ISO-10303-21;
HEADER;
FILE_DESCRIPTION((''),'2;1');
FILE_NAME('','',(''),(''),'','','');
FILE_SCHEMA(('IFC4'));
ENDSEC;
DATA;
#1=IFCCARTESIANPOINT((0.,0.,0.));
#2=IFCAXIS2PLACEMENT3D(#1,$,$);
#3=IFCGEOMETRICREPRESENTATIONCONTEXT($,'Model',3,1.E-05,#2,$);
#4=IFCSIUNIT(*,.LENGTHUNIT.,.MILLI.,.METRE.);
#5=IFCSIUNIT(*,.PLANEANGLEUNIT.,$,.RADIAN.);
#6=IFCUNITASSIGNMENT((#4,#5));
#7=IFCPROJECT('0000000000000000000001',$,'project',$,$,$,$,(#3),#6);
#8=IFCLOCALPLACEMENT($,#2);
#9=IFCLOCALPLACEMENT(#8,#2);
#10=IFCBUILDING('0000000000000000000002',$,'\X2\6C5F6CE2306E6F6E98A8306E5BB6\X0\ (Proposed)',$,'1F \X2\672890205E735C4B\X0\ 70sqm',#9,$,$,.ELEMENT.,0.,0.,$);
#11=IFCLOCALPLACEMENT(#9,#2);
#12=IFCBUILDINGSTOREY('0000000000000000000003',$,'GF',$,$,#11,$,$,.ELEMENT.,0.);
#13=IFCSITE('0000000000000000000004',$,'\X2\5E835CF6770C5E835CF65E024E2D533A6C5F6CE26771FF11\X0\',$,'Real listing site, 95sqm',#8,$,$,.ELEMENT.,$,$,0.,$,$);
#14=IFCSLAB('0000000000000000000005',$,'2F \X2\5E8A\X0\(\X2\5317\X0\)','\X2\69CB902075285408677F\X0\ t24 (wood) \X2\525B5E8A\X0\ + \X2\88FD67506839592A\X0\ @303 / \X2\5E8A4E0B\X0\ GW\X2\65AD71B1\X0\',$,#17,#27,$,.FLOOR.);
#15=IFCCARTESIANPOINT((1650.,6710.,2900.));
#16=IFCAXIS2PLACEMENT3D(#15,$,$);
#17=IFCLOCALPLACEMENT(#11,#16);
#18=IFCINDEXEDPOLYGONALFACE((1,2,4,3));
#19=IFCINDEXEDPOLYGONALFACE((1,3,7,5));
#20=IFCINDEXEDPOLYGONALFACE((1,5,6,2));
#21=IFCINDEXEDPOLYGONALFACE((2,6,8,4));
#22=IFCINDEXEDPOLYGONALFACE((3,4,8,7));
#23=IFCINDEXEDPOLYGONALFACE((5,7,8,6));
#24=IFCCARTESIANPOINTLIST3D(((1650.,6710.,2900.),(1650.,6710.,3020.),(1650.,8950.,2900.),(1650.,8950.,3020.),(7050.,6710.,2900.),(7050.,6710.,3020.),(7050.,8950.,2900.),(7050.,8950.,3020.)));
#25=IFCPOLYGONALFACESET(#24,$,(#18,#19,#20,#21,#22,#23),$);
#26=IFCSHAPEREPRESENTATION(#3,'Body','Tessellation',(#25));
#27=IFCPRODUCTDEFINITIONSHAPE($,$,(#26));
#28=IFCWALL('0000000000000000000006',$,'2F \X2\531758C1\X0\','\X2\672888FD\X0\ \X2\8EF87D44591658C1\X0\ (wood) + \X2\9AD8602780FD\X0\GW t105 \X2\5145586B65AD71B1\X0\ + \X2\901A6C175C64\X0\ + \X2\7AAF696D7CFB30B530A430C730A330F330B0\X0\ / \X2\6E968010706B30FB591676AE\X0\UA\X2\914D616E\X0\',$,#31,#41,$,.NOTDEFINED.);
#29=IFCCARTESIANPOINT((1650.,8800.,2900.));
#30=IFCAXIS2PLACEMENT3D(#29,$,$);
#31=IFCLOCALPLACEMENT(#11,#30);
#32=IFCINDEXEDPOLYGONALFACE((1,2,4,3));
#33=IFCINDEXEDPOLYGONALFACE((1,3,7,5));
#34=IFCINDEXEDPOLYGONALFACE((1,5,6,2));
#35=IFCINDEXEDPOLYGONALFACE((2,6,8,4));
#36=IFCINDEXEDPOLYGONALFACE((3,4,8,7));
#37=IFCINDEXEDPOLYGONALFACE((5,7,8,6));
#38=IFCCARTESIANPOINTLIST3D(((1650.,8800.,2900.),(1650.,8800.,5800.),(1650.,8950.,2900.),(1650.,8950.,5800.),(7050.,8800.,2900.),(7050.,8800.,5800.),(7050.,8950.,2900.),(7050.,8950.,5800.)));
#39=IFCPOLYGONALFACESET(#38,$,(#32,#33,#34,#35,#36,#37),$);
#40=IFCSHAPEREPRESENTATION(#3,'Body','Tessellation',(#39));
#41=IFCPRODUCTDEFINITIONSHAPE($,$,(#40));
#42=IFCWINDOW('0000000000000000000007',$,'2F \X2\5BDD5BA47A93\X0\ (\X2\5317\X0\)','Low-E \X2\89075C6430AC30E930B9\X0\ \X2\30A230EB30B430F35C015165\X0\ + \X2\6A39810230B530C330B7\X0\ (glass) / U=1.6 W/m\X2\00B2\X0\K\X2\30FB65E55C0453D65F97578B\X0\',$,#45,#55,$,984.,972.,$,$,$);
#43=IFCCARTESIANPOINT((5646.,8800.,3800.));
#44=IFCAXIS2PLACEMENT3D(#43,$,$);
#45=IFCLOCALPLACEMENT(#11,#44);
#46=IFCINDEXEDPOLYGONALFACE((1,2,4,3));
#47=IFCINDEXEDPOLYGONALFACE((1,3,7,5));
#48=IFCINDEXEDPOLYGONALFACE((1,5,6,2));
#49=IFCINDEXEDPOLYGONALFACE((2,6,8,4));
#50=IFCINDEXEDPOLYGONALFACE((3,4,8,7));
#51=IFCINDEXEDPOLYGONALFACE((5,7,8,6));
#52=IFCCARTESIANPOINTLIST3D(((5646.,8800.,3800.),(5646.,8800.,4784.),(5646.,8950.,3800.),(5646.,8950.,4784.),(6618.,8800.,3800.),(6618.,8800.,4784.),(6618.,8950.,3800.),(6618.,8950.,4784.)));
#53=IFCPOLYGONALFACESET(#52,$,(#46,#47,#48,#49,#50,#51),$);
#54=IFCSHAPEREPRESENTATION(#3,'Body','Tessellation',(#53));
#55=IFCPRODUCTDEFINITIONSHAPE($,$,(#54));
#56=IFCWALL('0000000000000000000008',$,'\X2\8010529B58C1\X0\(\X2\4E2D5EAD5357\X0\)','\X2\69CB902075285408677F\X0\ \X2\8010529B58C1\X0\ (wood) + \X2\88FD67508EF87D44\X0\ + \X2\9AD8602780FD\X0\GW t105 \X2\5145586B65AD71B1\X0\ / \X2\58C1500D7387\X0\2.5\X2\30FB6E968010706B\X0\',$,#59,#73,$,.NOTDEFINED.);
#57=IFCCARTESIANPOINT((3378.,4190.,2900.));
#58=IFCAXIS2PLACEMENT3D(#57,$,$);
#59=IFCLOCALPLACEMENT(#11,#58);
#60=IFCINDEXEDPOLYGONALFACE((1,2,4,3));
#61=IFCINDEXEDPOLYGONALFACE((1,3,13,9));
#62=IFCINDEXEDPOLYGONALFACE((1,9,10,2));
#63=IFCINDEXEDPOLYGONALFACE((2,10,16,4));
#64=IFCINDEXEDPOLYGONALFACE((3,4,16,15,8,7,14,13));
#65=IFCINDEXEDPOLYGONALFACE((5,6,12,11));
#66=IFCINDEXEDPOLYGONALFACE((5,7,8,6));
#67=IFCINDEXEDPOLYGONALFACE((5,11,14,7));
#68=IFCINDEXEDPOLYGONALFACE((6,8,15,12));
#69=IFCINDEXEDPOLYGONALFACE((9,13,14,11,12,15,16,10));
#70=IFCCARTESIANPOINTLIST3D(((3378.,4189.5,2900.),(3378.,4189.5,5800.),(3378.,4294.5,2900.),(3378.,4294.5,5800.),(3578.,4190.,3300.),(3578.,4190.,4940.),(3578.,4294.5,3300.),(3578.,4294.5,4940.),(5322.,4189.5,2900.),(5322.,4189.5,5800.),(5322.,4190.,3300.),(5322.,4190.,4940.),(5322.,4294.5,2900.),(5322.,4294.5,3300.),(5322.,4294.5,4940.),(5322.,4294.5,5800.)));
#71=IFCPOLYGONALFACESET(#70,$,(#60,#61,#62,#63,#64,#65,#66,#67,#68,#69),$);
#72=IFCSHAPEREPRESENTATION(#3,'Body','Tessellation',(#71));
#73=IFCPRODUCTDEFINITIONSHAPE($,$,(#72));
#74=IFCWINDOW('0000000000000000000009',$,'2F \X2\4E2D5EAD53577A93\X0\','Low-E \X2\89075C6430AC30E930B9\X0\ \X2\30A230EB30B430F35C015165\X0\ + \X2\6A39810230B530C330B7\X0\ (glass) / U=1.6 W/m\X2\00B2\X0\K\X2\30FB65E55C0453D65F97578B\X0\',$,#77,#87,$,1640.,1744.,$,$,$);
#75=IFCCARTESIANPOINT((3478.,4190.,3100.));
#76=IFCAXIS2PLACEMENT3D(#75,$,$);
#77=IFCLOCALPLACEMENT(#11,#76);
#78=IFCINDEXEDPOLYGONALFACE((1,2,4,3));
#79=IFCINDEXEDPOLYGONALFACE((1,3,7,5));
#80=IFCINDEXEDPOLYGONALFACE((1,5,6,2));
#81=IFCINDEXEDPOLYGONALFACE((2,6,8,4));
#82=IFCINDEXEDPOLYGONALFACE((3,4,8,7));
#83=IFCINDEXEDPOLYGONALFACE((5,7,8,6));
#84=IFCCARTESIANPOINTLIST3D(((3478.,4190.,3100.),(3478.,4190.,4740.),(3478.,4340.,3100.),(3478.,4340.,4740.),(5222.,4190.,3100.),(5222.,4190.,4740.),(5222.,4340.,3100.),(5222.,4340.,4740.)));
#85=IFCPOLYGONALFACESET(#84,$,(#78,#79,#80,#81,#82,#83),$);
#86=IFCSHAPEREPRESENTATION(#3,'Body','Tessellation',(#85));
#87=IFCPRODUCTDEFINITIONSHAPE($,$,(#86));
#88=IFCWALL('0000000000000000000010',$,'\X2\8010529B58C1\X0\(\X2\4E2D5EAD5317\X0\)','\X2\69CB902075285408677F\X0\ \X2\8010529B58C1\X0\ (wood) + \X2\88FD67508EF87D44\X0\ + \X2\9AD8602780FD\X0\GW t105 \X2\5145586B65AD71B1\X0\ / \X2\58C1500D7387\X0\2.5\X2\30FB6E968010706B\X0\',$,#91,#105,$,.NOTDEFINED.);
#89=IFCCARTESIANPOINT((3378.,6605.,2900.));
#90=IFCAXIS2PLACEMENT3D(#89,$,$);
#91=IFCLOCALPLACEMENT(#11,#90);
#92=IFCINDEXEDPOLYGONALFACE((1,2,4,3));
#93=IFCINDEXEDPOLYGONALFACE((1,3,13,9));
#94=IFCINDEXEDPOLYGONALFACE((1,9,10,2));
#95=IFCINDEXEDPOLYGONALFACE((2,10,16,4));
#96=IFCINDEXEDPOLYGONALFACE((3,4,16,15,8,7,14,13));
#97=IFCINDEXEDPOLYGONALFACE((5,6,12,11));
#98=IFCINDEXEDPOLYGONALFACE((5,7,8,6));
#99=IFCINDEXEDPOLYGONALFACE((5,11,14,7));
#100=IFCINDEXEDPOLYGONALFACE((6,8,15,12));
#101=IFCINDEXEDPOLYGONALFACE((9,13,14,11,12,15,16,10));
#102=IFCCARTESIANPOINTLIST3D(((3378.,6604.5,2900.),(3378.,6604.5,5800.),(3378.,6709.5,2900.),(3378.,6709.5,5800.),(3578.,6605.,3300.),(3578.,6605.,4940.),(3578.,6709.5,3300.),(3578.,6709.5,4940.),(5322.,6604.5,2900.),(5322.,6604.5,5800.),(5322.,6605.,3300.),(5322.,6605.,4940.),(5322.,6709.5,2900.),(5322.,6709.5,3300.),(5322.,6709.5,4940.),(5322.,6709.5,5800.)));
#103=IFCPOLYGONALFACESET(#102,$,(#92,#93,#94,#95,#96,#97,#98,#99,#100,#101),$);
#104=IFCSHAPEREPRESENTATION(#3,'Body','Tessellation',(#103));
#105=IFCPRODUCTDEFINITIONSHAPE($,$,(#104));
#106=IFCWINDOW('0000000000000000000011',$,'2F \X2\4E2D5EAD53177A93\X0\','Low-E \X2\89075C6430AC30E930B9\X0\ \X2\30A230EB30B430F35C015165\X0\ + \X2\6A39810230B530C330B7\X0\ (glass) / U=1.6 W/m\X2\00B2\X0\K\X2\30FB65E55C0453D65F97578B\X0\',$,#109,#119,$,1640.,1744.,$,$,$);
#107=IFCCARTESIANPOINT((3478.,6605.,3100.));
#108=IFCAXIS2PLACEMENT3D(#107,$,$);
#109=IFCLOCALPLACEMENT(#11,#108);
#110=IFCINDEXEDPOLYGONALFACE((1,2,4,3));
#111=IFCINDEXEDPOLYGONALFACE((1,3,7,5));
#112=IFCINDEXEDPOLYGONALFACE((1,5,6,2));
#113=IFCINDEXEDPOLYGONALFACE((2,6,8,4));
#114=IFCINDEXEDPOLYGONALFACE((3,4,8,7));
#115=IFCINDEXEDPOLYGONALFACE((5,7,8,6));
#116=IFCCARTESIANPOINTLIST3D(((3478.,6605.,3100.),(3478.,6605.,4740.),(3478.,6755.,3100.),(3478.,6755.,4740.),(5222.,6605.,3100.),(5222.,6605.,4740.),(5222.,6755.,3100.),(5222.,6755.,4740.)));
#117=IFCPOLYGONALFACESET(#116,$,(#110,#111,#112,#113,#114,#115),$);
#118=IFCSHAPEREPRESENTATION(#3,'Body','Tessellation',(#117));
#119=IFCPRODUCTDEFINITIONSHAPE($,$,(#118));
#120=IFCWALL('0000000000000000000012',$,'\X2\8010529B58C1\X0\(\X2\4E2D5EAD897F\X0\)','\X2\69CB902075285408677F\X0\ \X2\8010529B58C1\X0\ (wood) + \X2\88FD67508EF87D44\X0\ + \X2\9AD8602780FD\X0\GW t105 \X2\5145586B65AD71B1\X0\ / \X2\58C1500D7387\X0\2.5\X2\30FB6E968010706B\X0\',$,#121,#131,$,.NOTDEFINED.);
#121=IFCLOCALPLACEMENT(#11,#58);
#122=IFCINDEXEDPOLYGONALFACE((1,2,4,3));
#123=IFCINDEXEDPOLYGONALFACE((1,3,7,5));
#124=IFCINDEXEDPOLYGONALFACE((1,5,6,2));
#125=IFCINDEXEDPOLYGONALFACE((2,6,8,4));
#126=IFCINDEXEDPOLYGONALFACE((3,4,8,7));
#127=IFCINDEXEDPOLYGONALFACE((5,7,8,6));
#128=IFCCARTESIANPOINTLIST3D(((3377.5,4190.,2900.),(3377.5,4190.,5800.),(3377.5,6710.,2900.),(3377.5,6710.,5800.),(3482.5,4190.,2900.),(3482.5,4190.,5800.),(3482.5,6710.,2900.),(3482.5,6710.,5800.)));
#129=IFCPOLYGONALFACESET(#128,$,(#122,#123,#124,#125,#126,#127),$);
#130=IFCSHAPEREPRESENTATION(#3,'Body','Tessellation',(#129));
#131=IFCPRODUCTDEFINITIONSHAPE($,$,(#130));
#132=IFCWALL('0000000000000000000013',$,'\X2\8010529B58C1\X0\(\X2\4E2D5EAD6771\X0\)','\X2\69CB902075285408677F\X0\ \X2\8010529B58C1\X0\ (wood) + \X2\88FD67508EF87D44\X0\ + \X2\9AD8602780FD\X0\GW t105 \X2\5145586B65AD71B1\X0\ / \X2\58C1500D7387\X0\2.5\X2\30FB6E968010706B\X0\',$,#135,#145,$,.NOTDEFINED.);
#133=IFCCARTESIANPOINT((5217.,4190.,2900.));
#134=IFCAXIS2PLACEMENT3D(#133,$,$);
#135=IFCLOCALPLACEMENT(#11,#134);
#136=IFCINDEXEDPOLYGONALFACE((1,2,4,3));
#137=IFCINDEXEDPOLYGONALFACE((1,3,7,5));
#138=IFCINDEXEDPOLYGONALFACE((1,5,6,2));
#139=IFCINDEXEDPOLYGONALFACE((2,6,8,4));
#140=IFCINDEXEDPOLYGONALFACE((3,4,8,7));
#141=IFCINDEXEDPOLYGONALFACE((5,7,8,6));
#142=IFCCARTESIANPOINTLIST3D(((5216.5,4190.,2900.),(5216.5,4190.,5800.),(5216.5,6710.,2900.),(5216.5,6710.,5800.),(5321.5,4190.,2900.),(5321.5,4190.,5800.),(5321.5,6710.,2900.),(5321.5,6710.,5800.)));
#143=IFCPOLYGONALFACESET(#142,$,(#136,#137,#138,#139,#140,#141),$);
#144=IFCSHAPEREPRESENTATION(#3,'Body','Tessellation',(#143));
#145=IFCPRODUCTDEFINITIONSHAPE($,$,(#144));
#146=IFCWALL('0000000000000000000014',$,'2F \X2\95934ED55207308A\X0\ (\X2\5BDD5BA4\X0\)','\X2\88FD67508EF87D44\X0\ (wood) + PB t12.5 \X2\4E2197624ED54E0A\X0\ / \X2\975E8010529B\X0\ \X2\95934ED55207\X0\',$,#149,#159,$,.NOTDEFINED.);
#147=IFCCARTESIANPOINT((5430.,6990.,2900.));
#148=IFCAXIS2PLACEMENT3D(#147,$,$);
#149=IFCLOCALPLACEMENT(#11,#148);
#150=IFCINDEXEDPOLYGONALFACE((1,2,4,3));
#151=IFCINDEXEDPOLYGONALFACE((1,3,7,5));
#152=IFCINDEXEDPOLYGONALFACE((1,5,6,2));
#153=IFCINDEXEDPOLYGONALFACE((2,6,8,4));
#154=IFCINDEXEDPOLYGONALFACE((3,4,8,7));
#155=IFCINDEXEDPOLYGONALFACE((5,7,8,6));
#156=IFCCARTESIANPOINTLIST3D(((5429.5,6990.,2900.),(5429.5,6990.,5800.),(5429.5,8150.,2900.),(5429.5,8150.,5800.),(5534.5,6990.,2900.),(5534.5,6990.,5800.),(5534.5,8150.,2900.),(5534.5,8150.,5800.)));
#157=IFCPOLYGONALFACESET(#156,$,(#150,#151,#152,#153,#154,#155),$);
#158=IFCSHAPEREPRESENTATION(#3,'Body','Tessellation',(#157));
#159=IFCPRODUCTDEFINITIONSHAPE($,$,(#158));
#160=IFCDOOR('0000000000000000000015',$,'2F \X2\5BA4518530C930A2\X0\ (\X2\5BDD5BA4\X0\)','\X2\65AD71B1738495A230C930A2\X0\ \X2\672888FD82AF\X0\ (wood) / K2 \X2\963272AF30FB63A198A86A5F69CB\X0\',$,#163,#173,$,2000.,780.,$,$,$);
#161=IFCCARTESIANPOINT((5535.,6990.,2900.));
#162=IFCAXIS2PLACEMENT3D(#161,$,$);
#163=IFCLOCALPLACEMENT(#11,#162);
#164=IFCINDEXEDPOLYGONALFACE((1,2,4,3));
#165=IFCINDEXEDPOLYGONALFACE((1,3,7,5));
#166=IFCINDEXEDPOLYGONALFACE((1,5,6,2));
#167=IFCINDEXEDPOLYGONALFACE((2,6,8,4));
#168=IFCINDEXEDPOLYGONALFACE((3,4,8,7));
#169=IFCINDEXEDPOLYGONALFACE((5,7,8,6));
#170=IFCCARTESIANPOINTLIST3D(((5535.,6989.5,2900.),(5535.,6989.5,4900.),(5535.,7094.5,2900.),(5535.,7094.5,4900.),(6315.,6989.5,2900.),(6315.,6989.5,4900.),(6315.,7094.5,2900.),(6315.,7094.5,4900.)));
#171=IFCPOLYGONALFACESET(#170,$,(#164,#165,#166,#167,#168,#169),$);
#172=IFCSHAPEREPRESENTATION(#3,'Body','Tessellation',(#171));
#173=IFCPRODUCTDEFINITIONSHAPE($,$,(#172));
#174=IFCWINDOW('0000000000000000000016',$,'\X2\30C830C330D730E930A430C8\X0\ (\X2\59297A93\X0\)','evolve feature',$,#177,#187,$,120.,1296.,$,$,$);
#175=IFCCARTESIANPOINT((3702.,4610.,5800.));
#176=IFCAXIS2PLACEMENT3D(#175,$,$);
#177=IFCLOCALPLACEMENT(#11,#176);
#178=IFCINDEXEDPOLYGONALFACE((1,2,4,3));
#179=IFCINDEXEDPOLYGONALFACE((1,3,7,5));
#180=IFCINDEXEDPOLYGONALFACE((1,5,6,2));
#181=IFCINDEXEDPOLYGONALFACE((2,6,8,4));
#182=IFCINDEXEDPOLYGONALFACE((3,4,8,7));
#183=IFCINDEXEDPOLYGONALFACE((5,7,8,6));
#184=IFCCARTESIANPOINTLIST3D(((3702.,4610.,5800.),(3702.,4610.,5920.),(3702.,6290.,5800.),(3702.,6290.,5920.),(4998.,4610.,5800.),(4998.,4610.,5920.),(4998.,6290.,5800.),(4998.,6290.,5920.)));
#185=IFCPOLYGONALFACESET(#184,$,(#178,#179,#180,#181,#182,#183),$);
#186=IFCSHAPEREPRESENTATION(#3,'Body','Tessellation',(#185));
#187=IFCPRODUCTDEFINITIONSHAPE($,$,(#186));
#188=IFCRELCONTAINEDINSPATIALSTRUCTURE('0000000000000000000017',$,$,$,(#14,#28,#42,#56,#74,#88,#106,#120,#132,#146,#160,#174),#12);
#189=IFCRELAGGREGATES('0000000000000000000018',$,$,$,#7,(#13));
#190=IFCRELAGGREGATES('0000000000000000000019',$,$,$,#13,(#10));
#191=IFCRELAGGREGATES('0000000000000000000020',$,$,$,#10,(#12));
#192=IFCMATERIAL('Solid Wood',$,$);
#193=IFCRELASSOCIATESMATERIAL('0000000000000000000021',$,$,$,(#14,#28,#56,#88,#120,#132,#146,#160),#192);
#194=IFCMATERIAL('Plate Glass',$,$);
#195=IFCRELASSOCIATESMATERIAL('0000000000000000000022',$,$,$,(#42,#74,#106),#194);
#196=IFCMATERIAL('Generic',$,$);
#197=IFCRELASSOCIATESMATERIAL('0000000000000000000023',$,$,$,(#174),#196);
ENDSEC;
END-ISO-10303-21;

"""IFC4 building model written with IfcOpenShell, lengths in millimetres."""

from ifc_helpers import new_model, si_unit, frame, frame_2d, origin, place, context, project, spatial, rectangle, extrude, material, element, fill, save


model = new_model("IFC4")

# Units and contexts
model_context = context("Model", 3, precision=1e-05, world=origin())
ifc_project = project(units=[si_unit("LENGTHUNIT", "METRE", prefix="MILLI"), si_unit("PLANEANGLEUNIT", "RADIAN")], contexts=[model_context])

# Site, building, storey
site_placement = place(None, origin())
site = spatial("IfcSite", under=ifc_project, at=site_placement, Name="広島県広島市中区江波東１", ObjectType="Real listing site, 95sqm", CompositionType="ELEMENT", RefElevation=0.0)
building_placement = place(site_placement, origin())
building = spatial("IfcBuilding", under=site, at=building_placement, Name="江波の潮風の家 (Proposed)", ObjectType="1F 木造平屋 70sqm", CompositionType="ELEMENT", ElevationOfRefHeight=0.0, ElevationOfTerrain=0.0)
storey_placement = place(building_placement, origin())
storey = spatial("IfcBuildingStorey", under=building, at=storey_placement, Name="GF", CompositionType="ELEMENT", Elevation=0.0)

# Slab
ifc_material_1 = material(Name="Solid Wood")
slab_placement = place(storey_placement, frame((1650.0, 6710.0, 2900.0)))
element("IfcSlab", 1, at=slab_placement, inside=storey, material=ifc_material_1, Name="2F 床(北)", Description="構造用合板 t24 (wood) 剛床 + 製材根太 @303 / 床下 GW断熱", PredefinedType="FLOOR", context=model_context, shape_type="SweptSolid", body=[
    extrude(rectangle(XDim=5400.0, YDim=2240.0, at=frame_2d((2700.0, 1120.0))), frame((1650.0, 6710.0, 2900.0)), (0.0, 0.0, 1.0), 120.0),
])

# Walls, openings, windows
wall_1_placement = place(storey_placement, frame((1650.0, 8800.0, 2900.0)))
wall_1 = element("IfcWall", 2, at=wall_1_placement, inside=storey, material=ifc_material_1, Name="2F 北壁", Description="木製 軸組外壁 (wood) + 高性能GW t105 充填断熱 + 通気層 + 窯業系サイディング / 準耐火・外皮UA配慮", PredefinedType="NOTDEFINED", context=model_context, shape_type="SweptSolid", body=[
    extrude(rectangle(XDim=5400.0, YDim=150.0, at=frame_2d((2700.0, 75.0))), frame((1650.0, 8800.0, 2900.0)), (0.0, 0.0, 1.0), 2900.0),
])
opening_1_placement = place(storey_placement, frame((5646.0, 8800.0, 3800.0)))
opening_1 = element("IfcOpeningElement", 3, at=opening_1_placement, cuts=wall_1, PredefinedType="NOTDEFINED", context=model_context, shape_type="SweptSolid", body=[
    extrude(rectangle(XDim=972.0, YDim=150.0, at=frame_2d((486.0, 75.0))), frame((5646.0, 8800.0, 3800.0)), (0.0, 0.0, 1.0), 984.0),
])
ifc_material_2 = material(Name="Plate Glass")
window_1_placement = place(storey_placement, frame((5646.0, 8800.0, 3800.0)))
window_1 = element("IfcWindow", 4, at=window_1_placement, inside=storey, material=ifc_material_2, Name="2F 寝室窓 (北)", Description="Low-E 複層ガラス アルゴン封入 + 樹脂サッシ (glass) / U=1.6 W/m²K・日射取得型", OverallHeight=984.0, OverallWidth=972.0, context=model_context, shape_type="SweptSolid", body=[
    extrude(rectangle(XDim=972.0, YDim=150.0, at=frame_2d((486.0, 75.0))), frame((5646.0, 8800.0, 3800.0)), (0.0, 0.0, 1.0), 984.0),
])
fill(opening_1, window_1)
wall_2_placement = place(storey_placement, frame((3378.0, 4190.0, 2900.0)))
wall_2 = element("IfcWall", 5, at=wall_2_placement, inside=storey, material=ifc_material_1, Name="耐力壁(中庭南)", Description="構造用合板 耐力壁 (wood) + 製材軸組 + 高性能GW t105 充填断熱 / 壁倍率2.5・準耐火", PredefinedType="NOTDEFINED", context=model_context, shape_type="SweptSolid", body=[
    extrude(rectangle(XDim=1944.0, YDim=105.0, at=frame_2d((972.0, 52.0))), frame((3378.0, 4190.0, 2900.0)), (0.0, 0.0, 1.0), 2900.0),
])
opening_2_placement = place(storey_placement, frame((3478.0, 4190.0, 3100.0)))
opening_2 = element("IfcOpeningElement", 6, at=opening_2_placement, cuts=wall_2, PredefinedType="NOTDEFINED", context=model_context, shape_type="SweptSolid", body=[
    extrude(rectangle(XDim=1744.0, YDim=150.0, at=frame_2d((872.0, 75.0))), frame((3478.0, 4190.0, 3100.0)), (0.0, 0.0, 1.0), 1640.0),
])
window_2_placement = place(storey_placement, frame((3478.0, 4190.0, 3100.0)))
window_2 = element("IfcWindow", 7, at=window_2_placement, inside=storey, material=ifc_material_2, Name="2F 中庭南窓", Description="Low-E 複層ガラス アルゴン封入 + 樹脂サッシ (glass) / U=1.6 W/m²K・日射取得型", OverallHeight=1640.0, OverallWidth=1744.0, context=model_context, shape_type="SweptSolid", body=[
    extrude(rectangle(XDim=1744.0, YDim=150.0, at=frame_2d((872.0, 75.0))), frame((3478.0, 4190.0, 3100.0)), (0.0, 0.0, 1.0), 1640.0),
])
fill(opening_2, window_2)
wall_3_placement = place(storey_placement, frame((3378.0, 6605.0, 2900.0)))
wall_3 = element("IfcWall", 8, at=wall_3_placement, inside=storey, material=ifc_material_1, Name="耐力壁(中庭北)", Description="構造用合板 耐力壁 (wood) + 製材軸組 + 高性能GW t105 充填断熱 / 壁倍率2.5・準耐火", PredefinedType="NOTDEFINED", context=model_context, shape_type="SweptSolid", body=[
    extrude(rectangle(XDim=1944.0, YDim=105.0, at=frame_2d((972.0, 52.0))), frame((3378.0, 6605.0, 2900.0)), (0.0, 0.0, 1.0), 2900.0),
])
opening_3_placement = place(storey_placement, frame((3478.0, 6605.0, 3100.0)))
opening_3 = element("IfcOpeningElement", 9, at=opening_3_placement, cuts=wall_3, PredefinedType="NOTDEFINED", context=model_context, shape_type="SweptSolid", body=[
    extrude(rectangle(XDim=1744.0, YDim=150.0, at=frame_2d((872.0, 75.0))), frame((3478.0, 6605.0, 3100.0)), (0.0, 0.0, 1.0), 1640.0),
])
window_3_placement = place(storey_placement, frame((3478.0, 6605.0, 3100.0)))
window_3 = element("IfcWindow", 10, at=window_3_placement, inside=storey, material=ifc_material_2, Name="2F 中庭北窓", Description="Low-E 複層ガラス アルゴン封入 + 樹脂サッシ (glass) / U=1.6 W/m²K・日射取得型", OverallHeight=1640.0, OverallWidth=1744.0, context=model_context, shape_type="SweptSolid", body=[
    extrude(rectangle(XDim=1744.0, YDim=150.0, at=frame_2d((872.0, 75.0))), frame((3478.0, 6605.0, 3100.0)), (0.0, 0.0, 1.0), 1640.0),
])
fill(opening_3, window_3)

# Walls
wall_4_placement = place(storey_placement, frame((3378.0, 4190.0, 2900.0)))
element("IfcWall", 11, at=wall_4_placement, inside=storey, material=ifc_material_1, Name="耐力壁(中庭西)", Description="構造用合板 耐力壁 (wood) + 製材軸組 + 高性能GW t105 充填断熱 / 壁倍率2.5・準耐火", PredefinedType="NOTDEFINED", context=model_context, shape_type="SweptSolid", body=[
    extrude(rectangle(XDim=105.0, YDim=2520.0, at=frame_2d((52.0, 1260.0))), frame((3378.0, 4190.0, 2900.0)), (0.0, 0.0, 1.0), 2900.0),
])
wall_5_placement = place(storey_placement, frame((5217.0, 4190.0, 2900.0)))
element("IfcWall", 12, at=wall_5_placement, inside=storey, material=ifc_material_1, Name="耐力壁(中庭東)", Description="構造用合板 耐力壁 (wood) + 製材軸組 + 高性能GW t105 充填断熱 / 壁倍率2.5・準耐火", PredefinedType="NOTDEFINED", context=model_context, shape_type="SweptSolid", body=[
    extrude(rectangle(XDim=105.0, YDim=2520.0, at=frame_2d((52.0, 1260.0))), frame((5217.0, 4190.0, 2900.0)), (0.0, 0.0, 1.0), 2900.0),
])
wall_6_placement = place(storey_placement, frame((5430.0, 6990.0, 2900.0)))
element("IfcWall", 13, at=wall_6_placement, inside=storey, material=ifc_material_1, Name="2F 間仕切り (寝室)", Description="製材軸組 (wood) + PB t12.5 両面仕上 / 非耐力 間仕切", PredefinedType="NOTDEFINED", context=model_context, shape_type="SweptSolid", body=[
    extrude(rectangle(XDim=105.0, YDim=1160.0, at=frame_2d((52.0, 580.0))), frame((5430.0, 6990.0, 2900.0)), (0.0, 0.0, 1.0), 2900.0),
])

# Door
door_placement = place(storey_placement, frame((5535.0, 6990.0, 2900.0)))
element("IfcDoor", 14, at=door_placement, inside=storey, material=ifc_material_1, Name="2F 室内ドア (寝室)", Description="断熱玄関ドア 木製芯 (wood) / K2 防犯・採風機構", OverallHeight=2000.0, OverallWidth=780.0, context=model_context, shape_type="SweptSolid", body=[
    extrude(rectangle(XDim=780.0, YDim=105.0, at=frame_2d((390.0, 52.0))), frame((5535.0, 6990.0, 2900.0)), (0.0, 0.0, 1.0), 2000.0),
])

# Window
ifc_material_3 = material(Name="Generic")
window_4_placement = place(storey_placement, frame((3702.0, 4610.0, 5800.0)))
element("IfcWindow", 15, at=window_4_placement, inside=storey, material=ifc_material_3, Name="トップライト (天窓)", Description="evolve feature", OverallHeight=120.0, OverallWidth=1296.0, context=model_context, shape_type="SweptSolid", body=[
    extrude(rectangle(XDim=1296.0, YDim=1680.0, at=frame_2d((648.0, 840.0))), frame((3702.0, 4610.0, 5800.0)), (0.0, 0.0, 1.0), 120.0),
])

save(model, "model.ifc")
